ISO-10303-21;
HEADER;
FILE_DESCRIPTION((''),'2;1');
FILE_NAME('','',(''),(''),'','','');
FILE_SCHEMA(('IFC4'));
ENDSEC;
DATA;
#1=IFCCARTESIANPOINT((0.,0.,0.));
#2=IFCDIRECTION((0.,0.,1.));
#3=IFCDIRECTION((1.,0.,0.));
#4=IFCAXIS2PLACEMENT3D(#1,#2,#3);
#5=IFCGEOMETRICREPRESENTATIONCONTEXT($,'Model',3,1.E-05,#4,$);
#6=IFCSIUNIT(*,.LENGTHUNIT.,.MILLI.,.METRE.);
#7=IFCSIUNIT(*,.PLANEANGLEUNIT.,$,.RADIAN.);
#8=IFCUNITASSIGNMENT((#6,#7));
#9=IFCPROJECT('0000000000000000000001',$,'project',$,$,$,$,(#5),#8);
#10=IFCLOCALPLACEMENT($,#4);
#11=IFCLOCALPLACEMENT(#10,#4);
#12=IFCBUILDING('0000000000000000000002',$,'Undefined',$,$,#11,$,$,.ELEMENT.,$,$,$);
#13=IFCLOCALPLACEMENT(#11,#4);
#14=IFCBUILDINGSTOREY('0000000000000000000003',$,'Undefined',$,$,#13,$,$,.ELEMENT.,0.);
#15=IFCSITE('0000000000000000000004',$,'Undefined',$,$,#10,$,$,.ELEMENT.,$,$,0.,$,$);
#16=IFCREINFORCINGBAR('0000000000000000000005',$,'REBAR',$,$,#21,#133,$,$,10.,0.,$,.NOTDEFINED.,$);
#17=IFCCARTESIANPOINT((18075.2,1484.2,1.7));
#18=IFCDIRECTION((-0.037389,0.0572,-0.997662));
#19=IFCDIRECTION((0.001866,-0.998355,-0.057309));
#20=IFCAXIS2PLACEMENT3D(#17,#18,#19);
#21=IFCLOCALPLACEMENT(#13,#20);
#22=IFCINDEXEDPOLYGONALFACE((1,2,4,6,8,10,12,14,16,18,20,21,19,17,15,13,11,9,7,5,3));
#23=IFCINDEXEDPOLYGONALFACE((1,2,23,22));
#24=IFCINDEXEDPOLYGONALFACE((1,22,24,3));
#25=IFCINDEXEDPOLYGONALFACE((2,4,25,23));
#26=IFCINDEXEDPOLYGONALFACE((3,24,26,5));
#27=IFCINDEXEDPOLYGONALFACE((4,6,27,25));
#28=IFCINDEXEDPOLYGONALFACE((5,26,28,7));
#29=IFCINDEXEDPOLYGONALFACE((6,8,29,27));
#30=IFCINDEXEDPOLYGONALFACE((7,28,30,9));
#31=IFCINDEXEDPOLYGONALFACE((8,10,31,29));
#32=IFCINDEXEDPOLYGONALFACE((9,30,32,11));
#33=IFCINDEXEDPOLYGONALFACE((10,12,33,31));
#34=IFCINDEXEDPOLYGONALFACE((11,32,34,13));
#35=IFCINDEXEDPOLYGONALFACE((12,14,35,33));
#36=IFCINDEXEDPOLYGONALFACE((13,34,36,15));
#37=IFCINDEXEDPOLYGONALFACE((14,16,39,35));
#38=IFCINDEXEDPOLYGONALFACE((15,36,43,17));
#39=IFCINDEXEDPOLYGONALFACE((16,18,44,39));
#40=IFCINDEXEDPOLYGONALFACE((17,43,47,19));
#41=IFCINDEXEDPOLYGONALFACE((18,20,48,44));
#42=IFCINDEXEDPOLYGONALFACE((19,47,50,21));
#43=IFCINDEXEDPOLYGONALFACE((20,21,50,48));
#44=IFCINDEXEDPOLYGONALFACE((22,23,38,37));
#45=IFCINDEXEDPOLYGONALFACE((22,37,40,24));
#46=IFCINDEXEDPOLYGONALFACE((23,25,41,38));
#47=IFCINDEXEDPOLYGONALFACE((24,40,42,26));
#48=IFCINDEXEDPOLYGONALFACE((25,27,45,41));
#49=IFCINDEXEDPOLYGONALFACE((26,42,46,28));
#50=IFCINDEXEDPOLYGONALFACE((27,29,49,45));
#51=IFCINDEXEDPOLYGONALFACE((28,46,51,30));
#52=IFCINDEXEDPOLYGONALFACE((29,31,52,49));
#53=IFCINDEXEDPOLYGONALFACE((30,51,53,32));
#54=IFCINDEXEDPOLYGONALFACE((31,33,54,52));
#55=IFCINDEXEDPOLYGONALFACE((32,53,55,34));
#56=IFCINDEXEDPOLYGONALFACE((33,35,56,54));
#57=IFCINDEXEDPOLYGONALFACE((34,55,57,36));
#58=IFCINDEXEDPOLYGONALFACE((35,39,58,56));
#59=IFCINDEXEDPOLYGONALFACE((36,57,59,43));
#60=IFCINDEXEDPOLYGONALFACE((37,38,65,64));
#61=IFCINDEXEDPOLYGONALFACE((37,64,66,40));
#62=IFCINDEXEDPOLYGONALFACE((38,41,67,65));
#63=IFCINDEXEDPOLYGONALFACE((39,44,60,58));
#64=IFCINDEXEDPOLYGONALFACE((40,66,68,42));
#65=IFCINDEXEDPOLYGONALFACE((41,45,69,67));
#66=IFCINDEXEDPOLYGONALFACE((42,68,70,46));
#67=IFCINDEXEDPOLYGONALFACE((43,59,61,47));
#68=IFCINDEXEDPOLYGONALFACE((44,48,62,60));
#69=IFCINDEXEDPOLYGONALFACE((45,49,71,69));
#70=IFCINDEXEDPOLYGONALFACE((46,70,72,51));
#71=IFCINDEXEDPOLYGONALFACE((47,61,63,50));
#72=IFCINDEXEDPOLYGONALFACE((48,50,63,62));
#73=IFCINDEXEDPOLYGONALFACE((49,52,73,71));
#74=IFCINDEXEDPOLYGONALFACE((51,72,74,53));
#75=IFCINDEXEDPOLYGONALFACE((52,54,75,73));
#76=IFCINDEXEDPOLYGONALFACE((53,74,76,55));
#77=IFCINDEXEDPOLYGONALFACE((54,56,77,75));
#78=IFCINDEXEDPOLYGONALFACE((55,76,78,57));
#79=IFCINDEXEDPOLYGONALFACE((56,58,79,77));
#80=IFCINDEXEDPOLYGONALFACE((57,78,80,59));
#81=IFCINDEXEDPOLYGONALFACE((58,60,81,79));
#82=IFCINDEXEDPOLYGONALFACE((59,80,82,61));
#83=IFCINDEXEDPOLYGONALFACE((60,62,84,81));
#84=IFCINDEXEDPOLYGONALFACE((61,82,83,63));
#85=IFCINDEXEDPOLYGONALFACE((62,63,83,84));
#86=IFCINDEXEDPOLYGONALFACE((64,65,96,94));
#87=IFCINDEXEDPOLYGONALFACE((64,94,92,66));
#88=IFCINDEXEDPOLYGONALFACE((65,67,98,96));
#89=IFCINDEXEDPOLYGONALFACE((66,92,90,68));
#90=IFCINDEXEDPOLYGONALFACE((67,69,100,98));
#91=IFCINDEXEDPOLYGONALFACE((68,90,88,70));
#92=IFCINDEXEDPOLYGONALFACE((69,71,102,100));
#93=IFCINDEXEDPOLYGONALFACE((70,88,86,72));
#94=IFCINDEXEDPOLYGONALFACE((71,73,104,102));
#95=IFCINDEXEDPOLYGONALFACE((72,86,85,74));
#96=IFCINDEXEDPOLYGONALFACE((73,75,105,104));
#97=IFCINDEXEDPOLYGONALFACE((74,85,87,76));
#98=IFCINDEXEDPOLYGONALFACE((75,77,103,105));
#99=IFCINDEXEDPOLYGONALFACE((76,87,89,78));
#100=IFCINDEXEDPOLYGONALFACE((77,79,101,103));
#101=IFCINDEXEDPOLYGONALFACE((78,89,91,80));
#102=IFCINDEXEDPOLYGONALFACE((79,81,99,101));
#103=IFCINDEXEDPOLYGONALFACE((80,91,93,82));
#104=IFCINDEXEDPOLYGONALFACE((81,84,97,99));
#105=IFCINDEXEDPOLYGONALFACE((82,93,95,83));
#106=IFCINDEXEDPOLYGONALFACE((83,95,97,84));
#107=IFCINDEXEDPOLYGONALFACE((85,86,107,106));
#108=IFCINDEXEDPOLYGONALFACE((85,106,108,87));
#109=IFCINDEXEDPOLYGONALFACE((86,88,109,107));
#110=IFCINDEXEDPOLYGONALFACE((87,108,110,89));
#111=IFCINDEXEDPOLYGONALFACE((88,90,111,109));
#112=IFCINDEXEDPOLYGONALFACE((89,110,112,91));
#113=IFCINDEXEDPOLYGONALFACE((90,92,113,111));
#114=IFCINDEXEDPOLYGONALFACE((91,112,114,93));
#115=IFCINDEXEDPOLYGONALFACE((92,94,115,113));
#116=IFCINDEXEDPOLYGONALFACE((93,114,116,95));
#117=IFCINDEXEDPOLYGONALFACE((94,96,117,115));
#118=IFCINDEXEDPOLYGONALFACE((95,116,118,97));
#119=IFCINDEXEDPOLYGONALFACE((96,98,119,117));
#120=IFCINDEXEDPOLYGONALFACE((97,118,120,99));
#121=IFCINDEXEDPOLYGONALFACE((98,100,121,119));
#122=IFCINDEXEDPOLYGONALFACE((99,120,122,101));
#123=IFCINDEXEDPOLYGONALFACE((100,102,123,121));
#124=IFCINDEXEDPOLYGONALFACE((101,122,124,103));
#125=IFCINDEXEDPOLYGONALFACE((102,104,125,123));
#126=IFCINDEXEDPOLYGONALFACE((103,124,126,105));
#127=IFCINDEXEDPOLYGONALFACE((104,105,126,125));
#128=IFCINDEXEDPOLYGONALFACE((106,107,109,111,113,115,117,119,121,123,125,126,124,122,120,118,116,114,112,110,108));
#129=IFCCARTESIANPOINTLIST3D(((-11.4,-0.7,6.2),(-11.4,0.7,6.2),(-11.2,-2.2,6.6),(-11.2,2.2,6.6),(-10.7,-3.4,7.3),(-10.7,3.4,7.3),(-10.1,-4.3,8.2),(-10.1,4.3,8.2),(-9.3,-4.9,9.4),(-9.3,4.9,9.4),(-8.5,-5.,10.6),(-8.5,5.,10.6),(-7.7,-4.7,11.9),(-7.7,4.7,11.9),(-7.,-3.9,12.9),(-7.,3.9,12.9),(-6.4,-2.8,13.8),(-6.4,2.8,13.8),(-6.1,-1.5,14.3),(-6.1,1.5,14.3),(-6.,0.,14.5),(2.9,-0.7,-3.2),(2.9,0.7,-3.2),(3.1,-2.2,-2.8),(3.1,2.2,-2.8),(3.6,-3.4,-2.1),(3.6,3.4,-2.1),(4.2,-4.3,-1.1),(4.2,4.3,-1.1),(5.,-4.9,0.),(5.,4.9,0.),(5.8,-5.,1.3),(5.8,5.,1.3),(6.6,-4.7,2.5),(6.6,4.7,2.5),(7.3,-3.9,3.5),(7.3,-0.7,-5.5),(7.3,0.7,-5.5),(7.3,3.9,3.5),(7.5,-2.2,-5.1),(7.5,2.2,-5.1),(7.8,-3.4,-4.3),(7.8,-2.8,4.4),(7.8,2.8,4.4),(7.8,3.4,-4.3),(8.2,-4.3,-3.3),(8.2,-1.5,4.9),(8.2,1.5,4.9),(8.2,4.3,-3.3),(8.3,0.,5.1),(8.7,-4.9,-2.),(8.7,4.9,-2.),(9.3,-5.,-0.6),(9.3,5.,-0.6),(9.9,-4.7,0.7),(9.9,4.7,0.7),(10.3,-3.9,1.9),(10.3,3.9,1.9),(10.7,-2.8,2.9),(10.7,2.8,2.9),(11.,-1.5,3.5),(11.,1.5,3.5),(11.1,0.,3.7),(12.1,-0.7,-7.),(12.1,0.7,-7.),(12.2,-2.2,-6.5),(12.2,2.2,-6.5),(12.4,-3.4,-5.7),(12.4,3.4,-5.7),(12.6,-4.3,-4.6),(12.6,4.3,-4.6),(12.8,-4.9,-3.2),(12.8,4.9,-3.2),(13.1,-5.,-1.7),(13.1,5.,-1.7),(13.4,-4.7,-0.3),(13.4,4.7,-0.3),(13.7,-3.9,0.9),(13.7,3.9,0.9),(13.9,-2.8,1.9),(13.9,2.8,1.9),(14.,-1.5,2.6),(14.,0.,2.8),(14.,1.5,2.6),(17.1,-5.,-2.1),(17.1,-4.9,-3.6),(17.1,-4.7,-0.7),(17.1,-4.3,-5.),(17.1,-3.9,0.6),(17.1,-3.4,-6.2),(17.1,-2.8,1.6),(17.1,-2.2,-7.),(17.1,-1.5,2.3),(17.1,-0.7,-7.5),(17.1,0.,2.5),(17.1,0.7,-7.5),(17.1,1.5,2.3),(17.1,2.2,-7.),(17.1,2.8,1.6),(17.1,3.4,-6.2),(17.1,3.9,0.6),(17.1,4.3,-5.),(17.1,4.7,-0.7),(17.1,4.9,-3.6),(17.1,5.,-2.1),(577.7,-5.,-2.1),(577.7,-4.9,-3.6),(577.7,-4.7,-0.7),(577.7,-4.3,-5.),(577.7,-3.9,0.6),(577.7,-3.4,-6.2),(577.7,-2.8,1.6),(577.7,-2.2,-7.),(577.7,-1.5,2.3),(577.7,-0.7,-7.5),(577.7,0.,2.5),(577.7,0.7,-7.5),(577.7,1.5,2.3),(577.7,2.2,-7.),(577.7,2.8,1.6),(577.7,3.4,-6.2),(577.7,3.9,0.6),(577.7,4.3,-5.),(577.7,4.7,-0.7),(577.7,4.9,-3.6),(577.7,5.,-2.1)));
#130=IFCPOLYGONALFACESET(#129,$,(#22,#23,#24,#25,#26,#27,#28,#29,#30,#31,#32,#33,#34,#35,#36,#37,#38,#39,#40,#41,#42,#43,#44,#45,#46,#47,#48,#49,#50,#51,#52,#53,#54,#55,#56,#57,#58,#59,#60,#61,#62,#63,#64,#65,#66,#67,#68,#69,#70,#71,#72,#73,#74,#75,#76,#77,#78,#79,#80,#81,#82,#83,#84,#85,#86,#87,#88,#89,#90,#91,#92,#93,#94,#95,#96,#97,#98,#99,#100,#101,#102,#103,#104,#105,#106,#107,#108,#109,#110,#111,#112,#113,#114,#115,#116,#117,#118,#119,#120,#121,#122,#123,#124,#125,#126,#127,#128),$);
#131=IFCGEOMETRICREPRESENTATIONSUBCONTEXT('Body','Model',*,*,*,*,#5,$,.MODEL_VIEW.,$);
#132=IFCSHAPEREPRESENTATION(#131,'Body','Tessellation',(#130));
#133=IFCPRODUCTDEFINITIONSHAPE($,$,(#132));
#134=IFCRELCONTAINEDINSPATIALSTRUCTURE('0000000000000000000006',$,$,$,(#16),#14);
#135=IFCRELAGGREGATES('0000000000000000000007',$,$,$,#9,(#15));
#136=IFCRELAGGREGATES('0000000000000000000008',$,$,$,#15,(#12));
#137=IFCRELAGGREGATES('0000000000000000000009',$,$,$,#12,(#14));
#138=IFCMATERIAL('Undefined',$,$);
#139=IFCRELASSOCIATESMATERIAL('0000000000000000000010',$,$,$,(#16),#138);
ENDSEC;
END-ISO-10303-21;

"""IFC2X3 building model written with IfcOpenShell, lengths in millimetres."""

from ifc_helpers import new_model, entity, si_unit, frame, origin_with_axes, place, context, subcontext, project, spatial, source, transform, mapped, material, element, save


model = new_model("IFC2X3")

# Units and contexts
model_context = context("Model", 3, precision=1e-05, world=origin_with_axes())
body_context = subcontext(model_context, "Body", "Model", "MODEL_VIEW")
ifc_project = project(units=[si_unit("LENGTHUNIT", "METRE", prefix="MILLI"), si_unit("PLANEANGLEUNIT", "RADIAN")], contexts=[model_context])

# Site, building, storey
site_placement = place(None, origin_with_axes())
site = spatial("IfcSite", under=ifc_project, at=site_placement, Name="Undefined", CompositionType="ELEMENT", RefElevation=0.0)
building_placement = place(site_placement, origin_with_axes())
building = spatial("IfcBuilding", under=site, at=building_placement, Name="Undefined", CompositionType="ELEMENT")
storey_placement = place(building_placement, origin_with_axes())
storey = spatial("IfcBuildingStorey", under=building, at=storey_placement, Name="Undefined", CompositionType="ELEMENT", Elevation=0.0)

# Reinforcing bar
ifc_material_1 = material(Name="Undefined")
shared_shape_1 = source(origin_with_axes(), body_context, "Body", "AdvancedSweptSolid", [
    entity("IfcSweptDiskSolid", entity("IfcCompositeCurve", [entity("IfcCompositeCurveSegment", "CONTINUOUS", True, entity("IfcTrimmedCurve", entity("IfcLine", entity("IfcCartesianPoint", [0.0, 0.0, 0.0]), entity("IfcVector", entity("IfcDirection", [0.835483, 0.0, -0.549516]), 1.0)), [entity("IfcParameterValue", 0.0)], [entity("IfcParameterValue", 17.082101)], True, "PARAMETER")), entity("IfcCompositeCurveSegment", "CONTINUOUS", True, entity("IfcTrimmedCurve", entity("IfcCircle", entity("IfcAxis2Placement3D", entity("IfcCartesianPoint", [25.8, 0.0, 8.2]), entity("IfcDirection", [0.0, -1.0, 0.0]), entity("IfcDirection", [-0.549516, 0.0, -0.835483])), 21.0), [entity("IfcParameterValue", 0.0)], [entity("IfcParameterValue", 0.581785)], True, "PARAMETER")), entity("IfcCompositeCurveSegment", "DISCONTINUOUS", True, entity("IfcTrimmedCurve", entity("IfcLine", entity("IfcCartesianPoint", [25.8, 0.0, -12.8]), entity("IfcVector", entity("IfcDirection", [1.0, 0.0, 0.0]), 1.0)), [entity("IfcParameterValue", 0.0)], [entity("IfcParameterValue", 560.593055)], True, "PARAMETER"))], False), 5.0, None, 0.0, 578.3),
])
reinforcing_bar_1_placement = place(storey_placement, frame((18075.2, 1484.2, 1.7), z_axis=(-0.037389, 0.0572, -0.997662), x_axis=(0.001866, -0.998355, -0.057309)))
element("IfcReinforcingBar", 1, at=reinforcing_bar_1_placement, inside=storey, material=ifc_material_1, Name="REBAR", BarRole="NOTDEFINED", CrossSectionArea=0.0, NominalDiameter=10.0, context=body_context, shape_type="MappedRepresentation", body=[
    mapped(shared_shape_1, transform((-8.7, 0.0, 10.3))),
])

save(model, "model.ifc")
